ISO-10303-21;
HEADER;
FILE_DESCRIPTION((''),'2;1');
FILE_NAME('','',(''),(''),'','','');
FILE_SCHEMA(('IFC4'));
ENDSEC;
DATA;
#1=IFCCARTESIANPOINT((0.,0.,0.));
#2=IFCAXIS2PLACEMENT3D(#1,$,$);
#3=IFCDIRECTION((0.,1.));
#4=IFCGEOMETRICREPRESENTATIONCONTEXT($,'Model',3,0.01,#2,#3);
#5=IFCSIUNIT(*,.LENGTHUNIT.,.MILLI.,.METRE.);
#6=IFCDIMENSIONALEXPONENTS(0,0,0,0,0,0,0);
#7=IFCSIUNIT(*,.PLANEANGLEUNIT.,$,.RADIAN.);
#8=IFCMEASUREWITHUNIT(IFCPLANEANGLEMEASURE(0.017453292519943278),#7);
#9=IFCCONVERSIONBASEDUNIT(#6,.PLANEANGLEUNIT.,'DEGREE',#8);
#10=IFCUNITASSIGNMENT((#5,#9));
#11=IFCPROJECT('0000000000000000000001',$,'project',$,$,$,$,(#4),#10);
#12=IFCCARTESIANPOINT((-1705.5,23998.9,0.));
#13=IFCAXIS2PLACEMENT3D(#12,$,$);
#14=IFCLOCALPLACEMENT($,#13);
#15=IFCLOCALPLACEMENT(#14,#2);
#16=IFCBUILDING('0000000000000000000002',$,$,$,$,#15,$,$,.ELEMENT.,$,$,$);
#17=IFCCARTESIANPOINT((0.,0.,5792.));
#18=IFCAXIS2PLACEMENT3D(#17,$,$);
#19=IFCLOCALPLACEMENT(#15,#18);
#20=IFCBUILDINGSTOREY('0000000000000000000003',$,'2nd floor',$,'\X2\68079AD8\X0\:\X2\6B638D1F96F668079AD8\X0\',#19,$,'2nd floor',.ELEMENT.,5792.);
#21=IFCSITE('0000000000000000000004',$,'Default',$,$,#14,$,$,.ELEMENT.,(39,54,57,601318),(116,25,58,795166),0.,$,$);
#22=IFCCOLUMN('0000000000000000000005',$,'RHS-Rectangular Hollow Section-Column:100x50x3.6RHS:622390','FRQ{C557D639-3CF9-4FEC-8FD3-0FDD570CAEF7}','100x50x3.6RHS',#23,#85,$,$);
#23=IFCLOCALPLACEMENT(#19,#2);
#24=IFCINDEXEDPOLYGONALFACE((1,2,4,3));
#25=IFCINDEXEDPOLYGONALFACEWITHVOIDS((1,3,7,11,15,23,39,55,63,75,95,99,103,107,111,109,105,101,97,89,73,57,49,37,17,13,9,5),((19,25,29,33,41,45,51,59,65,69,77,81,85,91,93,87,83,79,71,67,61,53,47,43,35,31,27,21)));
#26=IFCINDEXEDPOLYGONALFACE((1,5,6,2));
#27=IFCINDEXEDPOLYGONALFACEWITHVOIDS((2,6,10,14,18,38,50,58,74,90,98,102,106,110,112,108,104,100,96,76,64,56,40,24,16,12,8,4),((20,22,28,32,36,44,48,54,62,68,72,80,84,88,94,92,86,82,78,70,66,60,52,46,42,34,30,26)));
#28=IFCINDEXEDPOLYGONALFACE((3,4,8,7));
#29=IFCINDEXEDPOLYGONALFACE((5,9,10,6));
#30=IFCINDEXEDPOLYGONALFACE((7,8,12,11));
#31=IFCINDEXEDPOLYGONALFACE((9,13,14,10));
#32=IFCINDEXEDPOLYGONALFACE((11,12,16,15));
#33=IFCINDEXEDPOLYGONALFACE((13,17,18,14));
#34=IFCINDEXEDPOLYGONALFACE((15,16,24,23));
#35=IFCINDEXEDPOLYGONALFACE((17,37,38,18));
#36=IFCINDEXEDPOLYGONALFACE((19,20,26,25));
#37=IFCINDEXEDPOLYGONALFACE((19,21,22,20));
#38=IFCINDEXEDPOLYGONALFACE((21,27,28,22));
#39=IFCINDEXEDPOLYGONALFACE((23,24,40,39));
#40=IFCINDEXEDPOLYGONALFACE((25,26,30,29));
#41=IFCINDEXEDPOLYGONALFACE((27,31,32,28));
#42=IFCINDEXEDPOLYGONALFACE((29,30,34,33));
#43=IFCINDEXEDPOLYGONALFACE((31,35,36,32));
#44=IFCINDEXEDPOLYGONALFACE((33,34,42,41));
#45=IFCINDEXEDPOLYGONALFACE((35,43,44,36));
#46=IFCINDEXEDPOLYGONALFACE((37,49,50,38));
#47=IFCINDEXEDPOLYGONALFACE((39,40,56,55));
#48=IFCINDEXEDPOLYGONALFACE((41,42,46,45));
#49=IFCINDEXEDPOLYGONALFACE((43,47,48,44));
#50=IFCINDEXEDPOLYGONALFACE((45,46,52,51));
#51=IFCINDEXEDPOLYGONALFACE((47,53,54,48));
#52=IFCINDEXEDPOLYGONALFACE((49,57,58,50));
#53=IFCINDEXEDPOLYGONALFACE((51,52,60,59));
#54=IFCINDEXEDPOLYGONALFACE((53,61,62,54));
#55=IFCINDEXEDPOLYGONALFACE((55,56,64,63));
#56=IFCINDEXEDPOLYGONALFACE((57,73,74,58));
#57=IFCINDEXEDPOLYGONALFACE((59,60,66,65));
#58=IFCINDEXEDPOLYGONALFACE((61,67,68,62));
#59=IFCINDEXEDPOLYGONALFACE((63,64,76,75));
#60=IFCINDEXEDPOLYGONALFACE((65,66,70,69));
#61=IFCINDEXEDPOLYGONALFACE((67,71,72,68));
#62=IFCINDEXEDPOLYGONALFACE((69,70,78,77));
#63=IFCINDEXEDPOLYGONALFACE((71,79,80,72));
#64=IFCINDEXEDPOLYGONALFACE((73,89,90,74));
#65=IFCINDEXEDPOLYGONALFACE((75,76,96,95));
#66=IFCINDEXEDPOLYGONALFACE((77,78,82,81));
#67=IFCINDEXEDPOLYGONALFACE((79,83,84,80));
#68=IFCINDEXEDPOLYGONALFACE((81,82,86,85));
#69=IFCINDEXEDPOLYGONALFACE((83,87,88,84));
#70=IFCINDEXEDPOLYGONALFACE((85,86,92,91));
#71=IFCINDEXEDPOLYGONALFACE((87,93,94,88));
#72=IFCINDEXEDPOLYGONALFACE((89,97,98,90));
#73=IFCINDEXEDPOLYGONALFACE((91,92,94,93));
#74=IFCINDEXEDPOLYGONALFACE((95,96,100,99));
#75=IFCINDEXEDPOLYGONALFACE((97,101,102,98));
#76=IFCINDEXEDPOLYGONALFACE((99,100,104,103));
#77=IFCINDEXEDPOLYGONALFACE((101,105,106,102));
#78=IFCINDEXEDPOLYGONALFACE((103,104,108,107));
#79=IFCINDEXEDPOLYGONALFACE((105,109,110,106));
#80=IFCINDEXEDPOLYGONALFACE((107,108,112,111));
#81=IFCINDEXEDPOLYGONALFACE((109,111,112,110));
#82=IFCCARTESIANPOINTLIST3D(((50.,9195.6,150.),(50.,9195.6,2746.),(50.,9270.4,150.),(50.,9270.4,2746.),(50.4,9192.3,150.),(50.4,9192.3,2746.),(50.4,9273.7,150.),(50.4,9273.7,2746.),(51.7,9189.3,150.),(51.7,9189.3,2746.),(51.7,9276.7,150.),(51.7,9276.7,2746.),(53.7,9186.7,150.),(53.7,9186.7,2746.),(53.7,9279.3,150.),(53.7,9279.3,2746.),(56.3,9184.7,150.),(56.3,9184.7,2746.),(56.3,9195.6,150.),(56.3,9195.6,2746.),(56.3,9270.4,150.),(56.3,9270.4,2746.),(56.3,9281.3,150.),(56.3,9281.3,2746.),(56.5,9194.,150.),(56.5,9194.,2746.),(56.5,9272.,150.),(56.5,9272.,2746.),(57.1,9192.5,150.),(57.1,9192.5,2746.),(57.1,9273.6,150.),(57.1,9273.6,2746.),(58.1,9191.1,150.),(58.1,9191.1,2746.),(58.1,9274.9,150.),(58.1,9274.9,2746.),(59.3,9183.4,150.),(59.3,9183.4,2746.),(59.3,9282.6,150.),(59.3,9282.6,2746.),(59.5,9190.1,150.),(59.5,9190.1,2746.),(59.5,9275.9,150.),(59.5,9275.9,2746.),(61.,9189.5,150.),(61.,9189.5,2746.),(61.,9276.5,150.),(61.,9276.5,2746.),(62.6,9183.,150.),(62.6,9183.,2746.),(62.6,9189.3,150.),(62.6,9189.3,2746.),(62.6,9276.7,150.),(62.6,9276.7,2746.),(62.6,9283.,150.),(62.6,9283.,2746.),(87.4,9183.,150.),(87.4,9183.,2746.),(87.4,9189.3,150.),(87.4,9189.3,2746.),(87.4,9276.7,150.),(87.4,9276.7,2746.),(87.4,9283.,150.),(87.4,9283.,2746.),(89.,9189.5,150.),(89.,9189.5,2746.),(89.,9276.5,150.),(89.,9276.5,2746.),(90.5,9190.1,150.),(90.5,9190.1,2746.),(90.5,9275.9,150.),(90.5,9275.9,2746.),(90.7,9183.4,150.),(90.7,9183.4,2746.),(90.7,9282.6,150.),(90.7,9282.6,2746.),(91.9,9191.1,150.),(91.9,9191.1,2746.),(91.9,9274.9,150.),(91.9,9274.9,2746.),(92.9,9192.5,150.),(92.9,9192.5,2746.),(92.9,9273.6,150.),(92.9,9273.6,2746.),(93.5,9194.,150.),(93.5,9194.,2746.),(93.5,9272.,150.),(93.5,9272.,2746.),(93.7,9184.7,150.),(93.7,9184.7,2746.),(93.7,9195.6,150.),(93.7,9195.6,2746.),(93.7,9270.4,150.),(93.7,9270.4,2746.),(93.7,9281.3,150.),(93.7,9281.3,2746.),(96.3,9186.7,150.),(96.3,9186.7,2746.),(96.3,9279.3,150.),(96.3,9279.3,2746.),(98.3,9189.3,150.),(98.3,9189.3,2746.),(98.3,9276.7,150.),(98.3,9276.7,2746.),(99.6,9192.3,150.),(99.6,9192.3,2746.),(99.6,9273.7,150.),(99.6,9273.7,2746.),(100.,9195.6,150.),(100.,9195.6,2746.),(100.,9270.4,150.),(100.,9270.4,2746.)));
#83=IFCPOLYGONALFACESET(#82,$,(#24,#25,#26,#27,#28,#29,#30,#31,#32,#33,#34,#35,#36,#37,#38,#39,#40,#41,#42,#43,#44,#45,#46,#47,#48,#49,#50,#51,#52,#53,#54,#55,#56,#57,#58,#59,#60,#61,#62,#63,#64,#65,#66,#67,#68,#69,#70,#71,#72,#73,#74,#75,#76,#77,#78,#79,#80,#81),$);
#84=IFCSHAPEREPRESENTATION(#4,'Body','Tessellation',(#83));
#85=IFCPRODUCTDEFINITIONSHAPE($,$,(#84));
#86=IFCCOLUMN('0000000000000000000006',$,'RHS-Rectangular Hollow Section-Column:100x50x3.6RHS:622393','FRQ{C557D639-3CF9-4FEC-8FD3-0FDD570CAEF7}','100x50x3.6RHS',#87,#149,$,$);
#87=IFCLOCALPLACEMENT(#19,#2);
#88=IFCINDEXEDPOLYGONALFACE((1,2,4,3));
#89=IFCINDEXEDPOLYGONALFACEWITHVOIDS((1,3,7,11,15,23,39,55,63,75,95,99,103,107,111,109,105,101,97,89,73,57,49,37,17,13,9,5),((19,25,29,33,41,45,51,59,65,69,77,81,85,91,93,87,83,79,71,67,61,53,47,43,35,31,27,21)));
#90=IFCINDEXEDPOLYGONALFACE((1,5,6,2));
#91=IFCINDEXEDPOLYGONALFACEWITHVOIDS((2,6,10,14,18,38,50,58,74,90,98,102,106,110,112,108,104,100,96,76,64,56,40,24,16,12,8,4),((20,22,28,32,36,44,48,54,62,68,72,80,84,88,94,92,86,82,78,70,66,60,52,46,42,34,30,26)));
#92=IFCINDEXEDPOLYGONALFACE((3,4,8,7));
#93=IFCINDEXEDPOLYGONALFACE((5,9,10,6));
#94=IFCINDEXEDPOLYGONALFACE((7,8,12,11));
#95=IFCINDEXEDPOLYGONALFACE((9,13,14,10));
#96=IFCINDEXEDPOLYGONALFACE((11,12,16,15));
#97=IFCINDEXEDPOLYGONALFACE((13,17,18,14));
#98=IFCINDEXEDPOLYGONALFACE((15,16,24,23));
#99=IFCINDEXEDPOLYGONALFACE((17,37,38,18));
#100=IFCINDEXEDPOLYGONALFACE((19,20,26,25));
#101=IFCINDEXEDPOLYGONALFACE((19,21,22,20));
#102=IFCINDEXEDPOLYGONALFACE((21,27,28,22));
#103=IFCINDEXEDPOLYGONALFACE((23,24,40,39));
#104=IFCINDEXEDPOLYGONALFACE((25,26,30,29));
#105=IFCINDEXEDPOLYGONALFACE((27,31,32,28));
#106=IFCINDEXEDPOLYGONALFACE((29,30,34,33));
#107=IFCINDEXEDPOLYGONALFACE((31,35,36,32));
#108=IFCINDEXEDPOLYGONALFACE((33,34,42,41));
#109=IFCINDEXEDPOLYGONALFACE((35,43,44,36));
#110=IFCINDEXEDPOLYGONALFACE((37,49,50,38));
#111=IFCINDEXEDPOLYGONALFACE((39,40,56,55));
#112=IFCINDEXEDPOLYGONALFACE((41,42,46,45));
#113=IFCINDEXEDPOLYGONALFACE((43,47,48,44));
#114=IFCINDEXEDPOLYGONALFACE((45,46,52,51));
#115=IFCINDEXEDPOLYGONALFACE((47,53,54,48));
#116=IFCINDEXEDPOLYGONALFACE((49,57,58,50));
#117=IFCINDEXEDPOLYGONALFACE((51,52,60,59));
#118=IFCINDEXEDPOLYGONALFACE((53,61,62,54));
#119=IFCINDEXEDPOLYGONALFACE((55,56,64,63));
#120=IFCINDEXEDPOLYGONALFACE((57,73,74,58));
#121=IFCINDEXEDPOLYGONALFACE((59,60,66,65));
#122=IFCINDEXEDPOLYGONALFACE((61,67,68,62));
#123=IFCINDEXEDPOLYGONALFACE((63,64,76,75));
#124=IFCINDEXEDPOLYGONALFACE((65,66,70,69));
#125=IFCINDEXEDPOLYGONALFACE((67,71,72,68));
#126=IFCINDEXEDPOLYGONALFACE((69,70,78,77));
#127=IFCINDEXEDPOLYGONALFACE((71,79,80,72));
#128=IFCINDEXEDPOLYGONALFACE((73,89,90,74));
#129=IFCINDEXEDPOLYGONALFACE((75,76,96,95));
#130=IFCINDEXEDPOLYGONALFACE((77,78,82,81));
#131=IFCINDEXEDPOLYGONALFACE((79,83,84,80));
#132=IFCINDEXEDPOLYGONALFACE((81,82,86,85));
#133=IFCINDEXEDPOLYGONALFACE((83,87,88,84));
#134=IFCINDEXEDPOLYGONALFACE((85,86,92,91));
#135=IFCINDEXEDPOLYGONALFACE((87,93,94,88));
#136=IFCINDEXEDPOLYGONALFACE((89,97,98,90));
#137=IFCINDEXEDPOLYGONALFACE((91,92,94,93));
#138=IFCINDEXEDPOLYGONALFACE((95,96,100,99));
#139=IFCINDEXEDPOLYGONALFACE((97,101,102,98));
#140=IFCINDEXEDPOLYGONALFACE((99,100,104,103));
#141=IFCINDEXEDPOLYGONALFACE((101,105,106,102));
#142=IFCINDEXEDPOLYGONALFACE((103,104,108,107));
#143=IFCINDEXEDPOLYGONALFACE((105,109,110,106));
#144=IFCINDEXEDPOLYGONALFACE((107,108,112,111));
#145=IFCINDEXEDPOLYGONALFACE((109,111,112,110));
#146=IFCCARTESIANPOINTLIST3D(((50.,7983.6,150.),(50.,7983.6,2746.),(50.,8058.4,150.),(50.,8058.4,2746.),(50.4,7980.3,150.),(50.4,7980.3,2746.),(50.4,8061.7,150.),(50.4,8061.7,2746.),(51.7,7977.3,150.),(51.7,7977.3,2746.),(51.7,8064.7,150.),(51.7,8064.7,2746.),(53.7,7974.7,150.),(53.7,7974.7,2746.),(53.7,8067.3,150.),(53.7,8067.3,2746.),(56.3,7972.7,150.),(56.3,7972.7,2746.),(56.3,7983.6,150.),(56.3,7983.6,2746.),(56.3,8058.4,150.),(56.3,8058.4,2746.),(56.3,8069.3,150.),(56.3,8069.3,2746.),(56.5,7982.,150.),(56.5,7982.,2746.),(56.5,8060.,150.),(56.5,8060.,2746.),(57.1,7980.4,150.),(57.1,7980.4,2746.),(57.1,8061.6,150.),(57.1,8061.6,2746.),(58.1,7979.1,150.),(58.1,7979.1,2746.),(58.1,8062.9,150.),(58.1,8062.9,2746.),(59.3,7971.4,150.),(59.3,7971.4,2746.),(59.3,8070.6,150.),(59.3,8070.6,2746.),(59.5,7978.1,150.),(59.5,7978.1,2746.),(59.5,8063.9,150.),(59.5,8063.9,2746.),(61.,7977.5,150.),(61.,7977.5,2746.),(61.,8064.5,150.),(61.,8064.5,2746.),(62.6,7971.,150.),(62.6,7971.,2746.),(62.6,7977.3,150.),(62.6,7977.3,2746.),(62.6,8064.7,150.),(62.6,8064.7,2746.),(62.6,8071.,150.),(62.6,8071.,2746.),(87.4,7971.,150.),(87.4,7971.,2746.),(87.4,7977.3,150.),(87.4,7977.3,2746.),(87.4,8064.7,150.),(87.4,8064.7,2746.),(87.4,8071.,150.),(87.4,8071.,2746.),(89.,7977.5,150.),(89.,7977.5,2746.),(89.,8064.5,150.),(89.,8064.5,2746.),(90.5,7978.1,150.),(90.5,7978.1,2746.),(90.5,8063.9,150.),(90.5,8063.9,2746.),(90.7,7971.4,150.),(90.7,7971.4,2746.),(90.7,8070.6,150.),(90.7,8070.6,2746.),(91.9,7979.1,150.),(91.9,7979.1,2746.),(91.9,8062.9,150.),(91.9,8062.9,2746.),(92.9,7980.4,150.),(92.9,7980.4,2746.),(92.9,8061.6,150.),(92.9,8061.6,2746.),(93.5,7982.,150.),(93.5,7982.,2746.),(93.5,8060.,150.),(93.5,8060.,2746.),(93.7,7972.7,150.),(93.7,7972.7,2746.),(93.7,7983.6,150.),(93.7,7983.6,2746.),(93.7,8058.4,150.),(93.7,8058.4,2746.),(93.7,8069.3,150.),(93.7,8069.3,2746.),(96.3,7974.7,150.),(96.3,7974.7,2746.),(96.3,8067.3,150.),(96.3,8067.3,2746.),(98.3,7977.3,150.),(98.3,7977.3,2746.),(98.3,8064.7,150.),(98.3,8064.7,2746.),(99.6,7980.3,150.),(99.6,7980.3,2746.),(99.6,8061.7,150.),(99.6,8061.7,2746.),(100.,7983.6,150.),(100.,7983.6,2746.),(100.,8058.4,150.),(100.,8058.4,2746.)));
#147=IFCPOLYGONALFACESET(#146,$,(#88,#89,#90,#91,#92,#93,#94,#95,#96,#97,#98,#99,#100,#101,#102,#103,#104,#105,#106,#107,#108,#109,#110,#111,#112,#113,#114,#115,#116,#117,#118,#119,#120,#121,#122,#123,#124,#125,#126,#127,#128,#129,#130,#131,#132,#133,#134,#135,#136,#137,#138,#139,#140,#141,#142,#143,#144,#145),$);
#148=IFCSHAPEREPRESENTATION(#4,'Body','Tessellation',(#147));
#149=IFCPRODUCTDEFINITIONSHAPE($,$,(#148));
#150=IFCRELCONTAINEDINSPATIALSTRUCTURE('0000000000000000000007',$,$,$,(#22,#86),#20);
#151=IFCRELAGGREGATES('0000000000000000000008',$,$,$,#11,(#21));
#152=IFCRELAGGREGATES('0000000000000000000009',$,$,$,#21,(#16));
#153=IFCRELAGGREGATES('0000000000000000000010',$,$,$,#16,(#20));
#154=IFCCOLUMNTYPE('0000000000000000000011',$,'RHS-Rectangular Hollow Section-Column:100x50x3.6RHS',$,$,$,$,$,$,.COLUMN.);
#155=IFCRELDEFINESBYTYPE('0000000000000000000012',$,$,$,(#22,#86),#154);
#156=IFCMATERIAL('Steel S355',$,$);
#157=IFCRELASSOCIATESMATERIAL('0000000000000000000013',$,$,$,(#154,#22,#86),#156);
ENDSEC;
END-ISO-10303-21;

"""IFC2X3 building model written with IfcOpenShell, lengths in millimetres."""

from ifc_helpers import new_model, entity, si_unit, converted_unit, direction, frame, origin, origin_2d, place, context, project, spatial, hollow_rectangle, extrude, clip, halfspace, material, type_object, element, save


model = new_model("IFC2X3")

# Units and contexts
model_context = context("Model", 3, precision=0.01, world=origin(), true_north=direction((0.0, 1.0)))
ifc_project = project(units=[si_unit("LENGTHUNIT", "METRE", prefix="MILLI"), converted_unit("PLANEANGLEUNIT", "DEGREE", entity("IfcPlaneAngleMeasure", 0.017453292519943278), si_unit("PLANEANGLEUNIT", "RADIAN"), dimensions=[0, 0, 0, 0, 0, 0, 0])], contexts=[model_context])

# Site, building, storey
site_placement = place(None, frame((-1705.5, 23998.9, 0.0)))
site = spatial("IfcSite", under=ifc_project, at=site_placement, Name="Default", CompositionType="ELEMENT", RefLatitude=(39, 54, 57, 601318), RefLongitude=(116, 25, 58, 795166), RefElevation=0.0)
building_placement = place(site_placement, origin())
building = spatial("IfcBuilding", under=site, at=building_placement, CompositionType="ELEMENT")
storey_placement = place(building_placement, frame((0.0, 0.0, 5792.0)))
storey = spatial("IfcBuildingStorey", under=building, at=storey_placement, Name="2nd floor", ObjectType="标高:正负零标高", LongName="2nd floor", CompositionType="ELEMENT", Elevation=5792.0)

# Columns
ifc_material_1 = material(Name="Steel S355")
column_type = type_object("IfcColumnType", Name="RHS-Rectangular Hollow Section-Column:100x50x3.6RHS", PredefinedType="COLUMN", material=ifc_material_1)
column_1_placement = place(storey_placement, frame((75.0, 9233.0, 2746.0), z_axis=(0.0, 0.0, 1.0), x_axis=(-1.0, 0.0, 0.0)))
element("IfcColumn", 1, at=column_1_placement, inside=storey, type_object=column_type, material=ifc_material_1, Name="RHS-Rectangular Hollow Section-Column:100x50x3.6RHS:622390", Description="FRQ{C557D639-3CF9-4FEC-8FD3-0FDD570CAEF7}", ObjectType="100x50x3.6RHS", context=model_context, shape_type="Clipping", body=[
    clip(extrude(hollow_rectangle(XDim=50.0, YDim=100.0, WallThickness=6.3, InnerFilletRadius=6.3, OuterFilletRadius=12.6, at=origin_2d()), origin(), (0.0, 0.0, -1.0), 2651.9), halfspace(frame((75.0, 9233.0, -2596.0), z_axis=(0.0, 0.0, 1.0), x_axis=(-1.0, 0.0, 0.0)), True)),
])
column_2_placement = place(storey_placement, frame((75.0, 8021.0, 2746.0), z_axis=(0.0, 0.0, 1.0), x_axis=(-1.0, 0.0, 0.0)))
element("IfcColumn", 2, at=column_2_placement, inside=storey, type_object=column_type, material=ifc_material_1, Name="RHS-Rectangular Hollow Section-Column:100x50x3.6RHS:622393", Description="FRQ{C557D639-3CF9-4FEC-8FD3-0FDD570CAEF7}", ObjectType="100x50x3.6RHS", context=model_context, shape_type="Clipping", body=[
    clip(extrude(hollow_rectangle(XDim=50.0, YDim=100.0, WallThickness=6.3, InnerFilletRadius=6.3, OuterFilletRadius=12.6, at=origin_2d()), origin(), (0.0, 0.0, -1.0), 2651.9), halfspace(frame((75.0, 8021.0, -2596.0), z_axis=(0.0, 0.0, 1.0), x_axis=(-1.0, 0.0, 0.0)), True)),
])

save(model, "model.ifc")
